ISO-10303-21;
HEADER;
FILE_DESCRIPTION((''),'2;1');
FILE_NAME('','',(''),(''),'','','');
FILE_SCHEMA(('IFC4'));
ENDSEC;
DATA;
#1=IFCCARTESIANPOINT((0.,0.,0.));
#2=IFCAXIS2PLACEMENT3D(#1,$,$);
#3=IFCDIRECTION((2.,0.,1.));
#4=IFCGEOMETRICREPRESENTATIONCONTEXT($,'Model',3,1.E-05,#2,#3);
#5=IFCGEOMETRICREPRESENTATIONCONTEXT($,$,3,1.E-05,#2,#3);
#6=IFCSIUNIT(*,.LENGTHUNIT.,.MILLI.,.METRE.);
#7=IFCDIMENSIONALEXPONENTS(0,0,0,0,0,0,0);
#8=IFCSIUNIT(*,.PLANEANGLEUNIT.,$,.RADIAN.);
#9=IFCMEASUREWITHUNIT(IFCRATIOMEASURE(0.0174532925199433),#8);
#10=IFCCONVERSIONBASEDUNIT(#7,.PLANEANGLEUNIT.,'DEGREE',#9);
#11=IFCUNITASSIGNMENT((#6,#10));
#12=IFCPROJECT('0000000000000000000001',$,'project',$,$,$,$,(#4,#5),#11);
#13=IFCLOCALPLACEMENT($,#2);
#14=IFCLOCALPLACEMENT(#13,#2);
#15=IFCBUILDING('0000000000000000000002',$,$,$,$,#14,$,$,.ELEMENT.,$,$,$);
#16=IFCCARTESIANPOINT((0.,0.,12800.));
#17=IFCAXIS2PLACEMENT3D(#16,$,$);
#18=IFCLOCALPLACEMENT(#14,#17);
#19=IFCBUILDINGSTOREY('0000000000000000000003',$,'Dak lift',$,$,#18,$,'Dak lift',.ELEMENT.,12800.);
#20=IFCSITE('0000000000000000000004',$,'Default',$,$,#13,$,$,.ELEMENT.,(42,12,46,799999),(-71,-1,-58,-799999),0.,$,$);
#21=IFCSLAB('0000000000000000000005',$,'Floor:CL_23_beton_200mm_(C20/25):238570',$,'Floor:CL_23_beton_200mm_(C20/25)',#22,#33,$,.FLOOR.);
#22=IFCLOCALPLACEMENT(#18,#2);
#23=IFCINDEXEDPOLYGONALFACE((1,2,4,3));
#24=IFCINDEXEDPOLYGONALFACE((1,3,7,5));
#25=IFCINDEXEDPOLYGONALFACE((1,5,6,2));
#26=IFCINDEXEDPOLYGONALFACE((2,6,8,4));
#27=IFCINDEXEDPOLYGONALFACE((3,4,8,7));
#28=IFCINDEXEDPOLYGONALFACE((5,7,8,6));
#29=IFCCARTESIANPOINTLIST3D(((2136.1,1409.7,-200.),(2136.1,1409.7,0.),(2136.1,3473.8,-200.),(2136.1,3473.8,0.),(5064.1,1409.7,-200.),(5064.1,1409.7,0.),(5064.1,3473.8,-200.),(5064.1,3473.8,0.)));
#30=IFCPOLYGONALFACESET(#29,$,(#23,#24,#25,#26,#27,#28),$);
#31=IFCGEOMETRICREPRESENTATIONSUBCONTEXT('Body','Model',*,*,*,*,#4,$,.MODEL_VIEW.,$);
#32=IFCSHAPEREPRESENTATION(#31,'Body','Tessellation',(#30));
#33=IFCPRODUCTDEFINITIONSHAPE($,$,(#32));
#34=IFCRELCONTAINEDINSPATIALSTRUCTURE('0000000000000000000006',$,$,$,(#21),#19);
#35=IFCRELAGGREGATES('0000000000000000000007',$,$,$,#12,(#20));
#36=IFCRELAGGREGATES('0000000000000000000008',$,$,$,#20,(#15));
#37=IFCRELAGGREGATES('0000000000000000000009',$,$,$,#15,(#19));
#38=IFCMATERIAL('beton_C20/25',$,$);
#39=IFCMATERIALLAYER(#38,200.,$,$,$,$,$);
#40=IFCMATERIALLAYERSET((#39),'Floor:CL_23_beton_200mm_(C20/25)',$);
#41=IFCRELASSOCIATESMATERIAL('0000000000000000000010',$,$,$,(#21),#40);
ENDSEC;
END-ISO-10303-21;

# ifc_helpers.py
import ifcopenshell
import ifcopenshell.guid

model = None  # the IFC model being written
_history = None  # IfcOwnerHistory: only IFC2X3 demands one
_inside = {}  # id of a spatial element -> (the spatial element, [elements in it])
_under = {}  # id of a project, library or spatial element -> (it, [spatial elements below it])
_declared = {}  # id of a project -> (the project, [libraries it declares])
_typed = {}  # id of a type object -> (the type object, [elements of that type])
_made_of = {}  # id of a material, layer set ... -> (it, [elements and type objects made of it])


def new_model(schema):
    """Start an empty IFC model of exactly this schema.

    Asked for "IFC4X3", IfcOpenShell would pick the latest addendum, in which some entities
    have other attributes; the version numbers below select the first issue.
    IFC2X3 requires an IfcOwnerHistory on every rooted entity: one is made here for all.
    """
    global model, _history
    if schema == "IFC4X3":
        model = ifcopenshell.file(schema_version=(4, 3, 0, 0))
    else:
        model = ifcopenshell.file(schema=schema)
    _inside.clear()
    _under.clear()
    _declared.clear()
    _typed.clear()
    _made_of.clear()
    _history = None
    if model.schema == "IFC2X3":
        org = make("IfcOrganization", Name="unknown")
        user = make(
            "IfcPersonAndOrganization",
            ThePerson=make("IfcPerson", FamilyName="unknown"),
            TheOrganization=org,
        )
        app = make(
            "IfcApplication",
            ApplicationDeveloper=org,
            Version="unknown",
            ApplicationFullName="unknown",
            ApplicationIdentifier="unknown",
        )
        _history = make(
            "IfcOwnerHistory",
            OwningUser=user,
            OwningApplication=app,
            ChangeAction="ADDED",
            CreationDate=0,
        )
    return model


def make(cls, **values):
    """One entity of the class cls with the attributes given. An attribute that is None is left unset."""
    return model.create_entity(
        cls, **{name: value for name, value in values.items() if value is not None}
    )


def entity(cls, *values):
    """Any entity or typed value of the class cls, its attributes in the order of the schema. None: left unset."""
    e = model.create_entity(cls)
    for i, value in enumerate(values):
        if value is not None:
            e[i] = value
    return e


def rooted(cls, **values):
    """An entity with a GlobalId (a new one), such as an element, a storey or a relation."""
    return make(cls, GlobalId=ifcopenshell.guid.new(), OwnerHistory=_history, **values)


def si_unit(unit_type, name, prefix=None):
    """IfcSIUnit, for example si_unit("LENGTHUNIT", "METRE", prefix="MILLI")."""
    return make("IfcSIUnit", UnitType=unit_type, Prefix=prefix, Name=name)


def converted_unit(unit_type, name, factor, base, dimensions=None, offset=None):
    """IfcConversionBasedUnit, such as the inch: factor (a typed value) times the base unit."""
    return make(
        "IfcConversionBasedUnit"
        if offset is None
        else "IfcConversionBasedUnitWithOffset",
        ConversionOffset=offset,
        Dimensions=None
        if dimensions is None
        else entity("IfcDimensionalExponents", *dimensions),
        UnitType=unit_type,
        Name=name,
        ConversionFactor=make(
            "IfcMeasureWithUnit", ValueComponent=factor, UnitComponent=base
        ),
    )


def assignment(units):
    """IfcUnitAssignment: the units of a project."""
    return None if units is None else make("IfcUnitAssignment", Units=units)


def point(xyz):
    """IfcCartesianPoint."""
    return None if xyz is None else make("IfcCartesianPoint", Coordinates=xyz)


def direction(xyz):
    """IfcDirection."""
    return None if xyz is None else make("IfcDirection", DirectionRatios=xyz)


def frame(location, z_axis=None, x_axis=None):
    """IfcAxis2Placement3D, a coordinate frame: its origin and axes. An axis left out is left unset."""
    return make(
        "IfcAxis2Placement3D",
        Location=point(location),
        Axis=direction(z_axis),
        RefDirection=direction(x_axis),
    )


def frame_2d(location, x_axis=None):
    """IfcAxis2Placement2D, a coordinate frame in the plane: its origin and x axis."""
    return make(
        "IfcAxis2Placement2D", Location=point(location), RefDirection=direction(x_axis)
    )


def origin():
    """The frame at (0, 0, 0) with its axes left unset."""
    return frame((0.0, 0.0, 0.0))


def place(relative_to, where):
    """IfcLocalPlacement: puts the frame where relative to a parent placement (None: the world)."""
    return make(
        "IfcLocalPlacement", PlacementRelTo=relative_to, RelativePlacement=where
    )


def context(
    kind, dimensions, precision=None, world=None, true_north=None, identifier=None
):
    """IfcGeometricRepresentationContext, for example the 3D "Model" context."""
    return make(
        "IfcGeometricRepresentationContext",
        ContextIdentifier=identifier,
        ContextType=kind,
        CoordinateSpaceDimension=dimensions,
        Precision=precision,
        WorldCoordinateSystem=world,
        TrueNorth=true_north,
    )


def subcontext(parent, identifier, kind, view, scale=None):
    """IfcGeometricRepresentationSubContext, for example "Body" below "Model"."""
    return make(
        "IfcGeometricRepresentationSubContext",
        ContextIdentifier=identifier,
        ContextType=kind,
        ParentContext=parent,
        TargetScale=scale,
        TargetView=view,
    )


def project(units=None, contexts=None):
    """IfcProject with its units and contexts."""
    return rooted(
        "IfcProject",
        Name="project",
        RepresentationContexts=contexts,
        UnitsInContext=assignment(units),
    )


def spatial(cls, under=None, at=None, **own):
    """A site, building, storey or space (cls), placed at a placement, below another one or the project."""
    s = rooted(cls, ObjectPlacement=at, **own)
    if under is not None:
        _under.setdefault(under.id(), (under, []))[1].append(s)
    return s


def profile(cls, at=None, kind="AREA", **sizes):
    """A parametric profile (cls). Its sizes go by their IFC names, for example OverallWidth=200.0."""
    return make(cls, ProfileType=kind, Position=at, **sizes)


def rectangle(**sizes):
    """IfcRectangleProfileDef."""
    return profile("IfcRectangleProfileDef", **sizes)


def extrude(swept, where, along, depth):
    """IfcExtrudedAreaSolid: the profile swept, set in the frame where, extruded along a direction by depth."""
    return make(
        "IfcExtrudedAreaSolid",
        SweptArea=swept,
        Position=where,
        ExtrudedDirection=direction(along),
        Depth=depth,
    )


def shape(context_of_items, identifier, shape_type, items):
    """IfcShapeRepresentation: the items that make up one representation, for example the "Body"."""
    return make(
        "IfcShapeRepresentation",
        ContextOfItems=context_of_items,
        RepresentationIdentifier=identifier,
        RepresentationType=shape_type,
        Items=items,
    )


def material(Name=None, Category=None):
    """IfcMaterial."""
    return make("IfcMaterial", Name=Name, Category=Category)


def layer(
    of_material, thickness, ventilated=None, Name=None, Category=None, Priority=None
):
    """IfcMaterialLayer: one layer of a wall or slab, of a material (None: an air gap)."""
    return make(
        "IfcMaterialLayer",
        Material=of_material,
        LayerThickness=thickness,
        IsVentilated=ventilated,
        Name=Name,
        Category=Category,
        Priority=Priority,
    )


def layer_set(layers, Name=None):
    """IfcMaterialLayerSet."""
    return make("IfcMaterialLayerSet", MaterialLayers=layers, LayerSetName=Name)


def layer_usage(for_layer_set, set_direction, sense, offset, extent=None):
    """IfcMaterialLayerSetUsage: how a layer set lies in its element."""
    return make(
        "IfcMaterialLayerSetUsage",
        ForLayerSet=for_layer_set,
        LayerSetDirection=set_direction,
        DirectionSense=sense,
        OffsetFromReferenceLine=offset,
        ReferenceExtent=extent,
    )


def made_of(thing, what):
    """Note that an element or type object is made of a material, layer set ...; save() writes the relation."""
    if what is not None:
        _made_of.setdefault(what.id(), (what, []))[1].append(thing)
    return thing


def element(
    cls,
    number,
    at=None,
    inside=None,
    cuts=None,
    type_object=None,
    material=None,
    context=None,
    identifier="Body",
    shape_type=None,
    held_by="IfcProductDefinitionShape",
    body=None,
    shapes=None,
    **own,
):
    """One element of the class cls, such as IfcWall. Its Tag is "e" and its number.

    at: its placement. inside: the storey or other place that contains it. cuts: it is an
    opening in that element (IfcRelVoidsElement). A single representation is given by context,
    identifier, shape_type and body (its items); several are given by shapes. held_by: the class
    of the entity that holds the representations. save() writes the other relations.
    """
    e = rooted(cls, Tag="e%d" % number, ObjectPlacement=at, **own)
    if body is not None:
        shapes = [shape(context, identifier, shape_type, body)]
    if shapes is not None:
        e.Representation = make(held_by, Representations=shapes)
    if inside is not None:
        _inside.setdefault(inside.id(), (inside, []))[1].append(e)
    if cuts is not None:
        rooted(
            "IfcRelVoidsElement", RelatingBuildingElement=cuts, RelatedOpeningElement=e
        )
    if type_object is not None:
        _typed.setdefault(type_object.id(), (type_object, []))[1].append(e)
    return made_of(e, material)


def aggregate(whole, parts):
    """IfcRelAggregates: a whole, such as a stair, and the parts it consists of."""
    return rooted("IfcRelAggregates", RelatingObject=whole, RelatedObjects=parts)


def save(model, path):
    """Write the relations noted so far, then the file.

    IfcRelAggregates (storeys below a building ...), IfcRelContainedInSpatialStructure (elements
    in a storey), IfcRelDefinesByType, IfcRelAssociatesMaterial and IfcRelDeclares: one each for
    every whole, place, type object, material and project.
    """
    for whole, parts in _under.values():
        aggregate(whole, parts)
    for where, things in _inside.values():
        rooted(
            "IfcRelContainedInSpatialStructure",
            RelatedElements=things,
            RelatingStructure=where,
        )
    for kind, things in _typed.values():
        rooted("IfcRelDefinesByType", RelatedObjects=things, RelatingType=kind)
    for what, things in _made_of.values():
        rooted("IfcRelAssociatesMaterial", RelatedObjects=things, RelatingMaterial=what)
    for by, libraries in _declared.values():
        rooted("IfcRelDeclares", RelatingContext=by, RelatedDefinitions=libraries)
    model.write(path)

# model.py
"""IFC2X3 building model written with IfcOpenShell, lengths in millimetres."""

from ifc_helpers import new_model, entity, si_unit, converted_unit, direction, frame, frame_2d, origin, place, context, subcontext, project, spatial, rectangle, extrude, material, layer, layer_set, layer_usage, element, save


model = new_model("IFC2X3")

# Units and contexts
model_context = context("Model", 3, precision=1e-05, world=origin(), true_north=direction((2.0, 0.0, 1.0)))
context_of_model = context(None, 3, precision=1e-05, world=origin(), true_north=direction((2.0, 0.0, 1.0)))
body_context = subcontext(model_context, "Body", "Model", "MODEL_VIEW")
ifc_project = project(units=[si_unit("LENGTHUNIT", "METRE", prefix="MILLI"), converted_unit("PLANEANGLEUNIT", "DEGREE", entity("IfcRatioMeasure", 0.0174532925199433), si_unit("PLANEANGLEUNIT", "RADIAN"), dimensions=[0, 0, 0, 0, 0, 0, 0])], contexts=[model_context, context_of_model])

# Site, building, storey
site_placement = place(None, origin())
site = spatial("IfcSite", under=ifc_project, at=site_placement, Name="Default", CompositionType="ELEMENT", RefLatitude=(42, 12, 46, 799999), RefLongitude=(-71, -1, -58, -799999), RefElevation=0.0)
building_placement = place(site_placement, origin())
building = spatial("IfcBuilding", under=site, at=building_placement, CompositionType="ELEMENT")
storey_placement = place(building_placement, frame((0.0, 0.0, 12800.0)))
storey = spatial("IfcBuildingStorey", under=building, at=storey_placement, Name="Dak lift", LongName="Dak lift", CompositionType="ELEMENT", Elevation=12800.0)

# Slab
ifc_material = material(Name="beton_C20/25")
ifc_layer = layer(ifc_material, 200.0)
ifc_layer_set = layer_set([ifc_layer], Name="Floor:CL_23_beton_200mm_(C20/25)")
ifc_layer_usage = layer_usage(ifc_layer_set, "AXIS3", "POSITIVE", 0.0)
slab_placement = place(storey_placement, origin())
element("IfcSlab", 1, at=slab_placement, inside=storey, material=ifc_layer_usage, Name="Floor:CL_23_beton_200mm_(C20/25):238570", ObjectType="Floor:CL_23_beton_200mm_(C20/25)", PredefinedType="FLOOR", context=body_context, shape_type="SweptSolid", body=[
    extrude(rectangle(XDim=2064.1, YDim=2928.0, at=frame_2d((0.0, 0.0), x_axis=(1.0, 0.0))), frame((3600.1, 2441.8, 0.0), z_axis=(0.0, 0.0, -1.0), x_axis=(0.0, 1.0, 0.0)), (0.0, 0.0, 1.0), 200.0),
])

save(model, "model.ifc")
